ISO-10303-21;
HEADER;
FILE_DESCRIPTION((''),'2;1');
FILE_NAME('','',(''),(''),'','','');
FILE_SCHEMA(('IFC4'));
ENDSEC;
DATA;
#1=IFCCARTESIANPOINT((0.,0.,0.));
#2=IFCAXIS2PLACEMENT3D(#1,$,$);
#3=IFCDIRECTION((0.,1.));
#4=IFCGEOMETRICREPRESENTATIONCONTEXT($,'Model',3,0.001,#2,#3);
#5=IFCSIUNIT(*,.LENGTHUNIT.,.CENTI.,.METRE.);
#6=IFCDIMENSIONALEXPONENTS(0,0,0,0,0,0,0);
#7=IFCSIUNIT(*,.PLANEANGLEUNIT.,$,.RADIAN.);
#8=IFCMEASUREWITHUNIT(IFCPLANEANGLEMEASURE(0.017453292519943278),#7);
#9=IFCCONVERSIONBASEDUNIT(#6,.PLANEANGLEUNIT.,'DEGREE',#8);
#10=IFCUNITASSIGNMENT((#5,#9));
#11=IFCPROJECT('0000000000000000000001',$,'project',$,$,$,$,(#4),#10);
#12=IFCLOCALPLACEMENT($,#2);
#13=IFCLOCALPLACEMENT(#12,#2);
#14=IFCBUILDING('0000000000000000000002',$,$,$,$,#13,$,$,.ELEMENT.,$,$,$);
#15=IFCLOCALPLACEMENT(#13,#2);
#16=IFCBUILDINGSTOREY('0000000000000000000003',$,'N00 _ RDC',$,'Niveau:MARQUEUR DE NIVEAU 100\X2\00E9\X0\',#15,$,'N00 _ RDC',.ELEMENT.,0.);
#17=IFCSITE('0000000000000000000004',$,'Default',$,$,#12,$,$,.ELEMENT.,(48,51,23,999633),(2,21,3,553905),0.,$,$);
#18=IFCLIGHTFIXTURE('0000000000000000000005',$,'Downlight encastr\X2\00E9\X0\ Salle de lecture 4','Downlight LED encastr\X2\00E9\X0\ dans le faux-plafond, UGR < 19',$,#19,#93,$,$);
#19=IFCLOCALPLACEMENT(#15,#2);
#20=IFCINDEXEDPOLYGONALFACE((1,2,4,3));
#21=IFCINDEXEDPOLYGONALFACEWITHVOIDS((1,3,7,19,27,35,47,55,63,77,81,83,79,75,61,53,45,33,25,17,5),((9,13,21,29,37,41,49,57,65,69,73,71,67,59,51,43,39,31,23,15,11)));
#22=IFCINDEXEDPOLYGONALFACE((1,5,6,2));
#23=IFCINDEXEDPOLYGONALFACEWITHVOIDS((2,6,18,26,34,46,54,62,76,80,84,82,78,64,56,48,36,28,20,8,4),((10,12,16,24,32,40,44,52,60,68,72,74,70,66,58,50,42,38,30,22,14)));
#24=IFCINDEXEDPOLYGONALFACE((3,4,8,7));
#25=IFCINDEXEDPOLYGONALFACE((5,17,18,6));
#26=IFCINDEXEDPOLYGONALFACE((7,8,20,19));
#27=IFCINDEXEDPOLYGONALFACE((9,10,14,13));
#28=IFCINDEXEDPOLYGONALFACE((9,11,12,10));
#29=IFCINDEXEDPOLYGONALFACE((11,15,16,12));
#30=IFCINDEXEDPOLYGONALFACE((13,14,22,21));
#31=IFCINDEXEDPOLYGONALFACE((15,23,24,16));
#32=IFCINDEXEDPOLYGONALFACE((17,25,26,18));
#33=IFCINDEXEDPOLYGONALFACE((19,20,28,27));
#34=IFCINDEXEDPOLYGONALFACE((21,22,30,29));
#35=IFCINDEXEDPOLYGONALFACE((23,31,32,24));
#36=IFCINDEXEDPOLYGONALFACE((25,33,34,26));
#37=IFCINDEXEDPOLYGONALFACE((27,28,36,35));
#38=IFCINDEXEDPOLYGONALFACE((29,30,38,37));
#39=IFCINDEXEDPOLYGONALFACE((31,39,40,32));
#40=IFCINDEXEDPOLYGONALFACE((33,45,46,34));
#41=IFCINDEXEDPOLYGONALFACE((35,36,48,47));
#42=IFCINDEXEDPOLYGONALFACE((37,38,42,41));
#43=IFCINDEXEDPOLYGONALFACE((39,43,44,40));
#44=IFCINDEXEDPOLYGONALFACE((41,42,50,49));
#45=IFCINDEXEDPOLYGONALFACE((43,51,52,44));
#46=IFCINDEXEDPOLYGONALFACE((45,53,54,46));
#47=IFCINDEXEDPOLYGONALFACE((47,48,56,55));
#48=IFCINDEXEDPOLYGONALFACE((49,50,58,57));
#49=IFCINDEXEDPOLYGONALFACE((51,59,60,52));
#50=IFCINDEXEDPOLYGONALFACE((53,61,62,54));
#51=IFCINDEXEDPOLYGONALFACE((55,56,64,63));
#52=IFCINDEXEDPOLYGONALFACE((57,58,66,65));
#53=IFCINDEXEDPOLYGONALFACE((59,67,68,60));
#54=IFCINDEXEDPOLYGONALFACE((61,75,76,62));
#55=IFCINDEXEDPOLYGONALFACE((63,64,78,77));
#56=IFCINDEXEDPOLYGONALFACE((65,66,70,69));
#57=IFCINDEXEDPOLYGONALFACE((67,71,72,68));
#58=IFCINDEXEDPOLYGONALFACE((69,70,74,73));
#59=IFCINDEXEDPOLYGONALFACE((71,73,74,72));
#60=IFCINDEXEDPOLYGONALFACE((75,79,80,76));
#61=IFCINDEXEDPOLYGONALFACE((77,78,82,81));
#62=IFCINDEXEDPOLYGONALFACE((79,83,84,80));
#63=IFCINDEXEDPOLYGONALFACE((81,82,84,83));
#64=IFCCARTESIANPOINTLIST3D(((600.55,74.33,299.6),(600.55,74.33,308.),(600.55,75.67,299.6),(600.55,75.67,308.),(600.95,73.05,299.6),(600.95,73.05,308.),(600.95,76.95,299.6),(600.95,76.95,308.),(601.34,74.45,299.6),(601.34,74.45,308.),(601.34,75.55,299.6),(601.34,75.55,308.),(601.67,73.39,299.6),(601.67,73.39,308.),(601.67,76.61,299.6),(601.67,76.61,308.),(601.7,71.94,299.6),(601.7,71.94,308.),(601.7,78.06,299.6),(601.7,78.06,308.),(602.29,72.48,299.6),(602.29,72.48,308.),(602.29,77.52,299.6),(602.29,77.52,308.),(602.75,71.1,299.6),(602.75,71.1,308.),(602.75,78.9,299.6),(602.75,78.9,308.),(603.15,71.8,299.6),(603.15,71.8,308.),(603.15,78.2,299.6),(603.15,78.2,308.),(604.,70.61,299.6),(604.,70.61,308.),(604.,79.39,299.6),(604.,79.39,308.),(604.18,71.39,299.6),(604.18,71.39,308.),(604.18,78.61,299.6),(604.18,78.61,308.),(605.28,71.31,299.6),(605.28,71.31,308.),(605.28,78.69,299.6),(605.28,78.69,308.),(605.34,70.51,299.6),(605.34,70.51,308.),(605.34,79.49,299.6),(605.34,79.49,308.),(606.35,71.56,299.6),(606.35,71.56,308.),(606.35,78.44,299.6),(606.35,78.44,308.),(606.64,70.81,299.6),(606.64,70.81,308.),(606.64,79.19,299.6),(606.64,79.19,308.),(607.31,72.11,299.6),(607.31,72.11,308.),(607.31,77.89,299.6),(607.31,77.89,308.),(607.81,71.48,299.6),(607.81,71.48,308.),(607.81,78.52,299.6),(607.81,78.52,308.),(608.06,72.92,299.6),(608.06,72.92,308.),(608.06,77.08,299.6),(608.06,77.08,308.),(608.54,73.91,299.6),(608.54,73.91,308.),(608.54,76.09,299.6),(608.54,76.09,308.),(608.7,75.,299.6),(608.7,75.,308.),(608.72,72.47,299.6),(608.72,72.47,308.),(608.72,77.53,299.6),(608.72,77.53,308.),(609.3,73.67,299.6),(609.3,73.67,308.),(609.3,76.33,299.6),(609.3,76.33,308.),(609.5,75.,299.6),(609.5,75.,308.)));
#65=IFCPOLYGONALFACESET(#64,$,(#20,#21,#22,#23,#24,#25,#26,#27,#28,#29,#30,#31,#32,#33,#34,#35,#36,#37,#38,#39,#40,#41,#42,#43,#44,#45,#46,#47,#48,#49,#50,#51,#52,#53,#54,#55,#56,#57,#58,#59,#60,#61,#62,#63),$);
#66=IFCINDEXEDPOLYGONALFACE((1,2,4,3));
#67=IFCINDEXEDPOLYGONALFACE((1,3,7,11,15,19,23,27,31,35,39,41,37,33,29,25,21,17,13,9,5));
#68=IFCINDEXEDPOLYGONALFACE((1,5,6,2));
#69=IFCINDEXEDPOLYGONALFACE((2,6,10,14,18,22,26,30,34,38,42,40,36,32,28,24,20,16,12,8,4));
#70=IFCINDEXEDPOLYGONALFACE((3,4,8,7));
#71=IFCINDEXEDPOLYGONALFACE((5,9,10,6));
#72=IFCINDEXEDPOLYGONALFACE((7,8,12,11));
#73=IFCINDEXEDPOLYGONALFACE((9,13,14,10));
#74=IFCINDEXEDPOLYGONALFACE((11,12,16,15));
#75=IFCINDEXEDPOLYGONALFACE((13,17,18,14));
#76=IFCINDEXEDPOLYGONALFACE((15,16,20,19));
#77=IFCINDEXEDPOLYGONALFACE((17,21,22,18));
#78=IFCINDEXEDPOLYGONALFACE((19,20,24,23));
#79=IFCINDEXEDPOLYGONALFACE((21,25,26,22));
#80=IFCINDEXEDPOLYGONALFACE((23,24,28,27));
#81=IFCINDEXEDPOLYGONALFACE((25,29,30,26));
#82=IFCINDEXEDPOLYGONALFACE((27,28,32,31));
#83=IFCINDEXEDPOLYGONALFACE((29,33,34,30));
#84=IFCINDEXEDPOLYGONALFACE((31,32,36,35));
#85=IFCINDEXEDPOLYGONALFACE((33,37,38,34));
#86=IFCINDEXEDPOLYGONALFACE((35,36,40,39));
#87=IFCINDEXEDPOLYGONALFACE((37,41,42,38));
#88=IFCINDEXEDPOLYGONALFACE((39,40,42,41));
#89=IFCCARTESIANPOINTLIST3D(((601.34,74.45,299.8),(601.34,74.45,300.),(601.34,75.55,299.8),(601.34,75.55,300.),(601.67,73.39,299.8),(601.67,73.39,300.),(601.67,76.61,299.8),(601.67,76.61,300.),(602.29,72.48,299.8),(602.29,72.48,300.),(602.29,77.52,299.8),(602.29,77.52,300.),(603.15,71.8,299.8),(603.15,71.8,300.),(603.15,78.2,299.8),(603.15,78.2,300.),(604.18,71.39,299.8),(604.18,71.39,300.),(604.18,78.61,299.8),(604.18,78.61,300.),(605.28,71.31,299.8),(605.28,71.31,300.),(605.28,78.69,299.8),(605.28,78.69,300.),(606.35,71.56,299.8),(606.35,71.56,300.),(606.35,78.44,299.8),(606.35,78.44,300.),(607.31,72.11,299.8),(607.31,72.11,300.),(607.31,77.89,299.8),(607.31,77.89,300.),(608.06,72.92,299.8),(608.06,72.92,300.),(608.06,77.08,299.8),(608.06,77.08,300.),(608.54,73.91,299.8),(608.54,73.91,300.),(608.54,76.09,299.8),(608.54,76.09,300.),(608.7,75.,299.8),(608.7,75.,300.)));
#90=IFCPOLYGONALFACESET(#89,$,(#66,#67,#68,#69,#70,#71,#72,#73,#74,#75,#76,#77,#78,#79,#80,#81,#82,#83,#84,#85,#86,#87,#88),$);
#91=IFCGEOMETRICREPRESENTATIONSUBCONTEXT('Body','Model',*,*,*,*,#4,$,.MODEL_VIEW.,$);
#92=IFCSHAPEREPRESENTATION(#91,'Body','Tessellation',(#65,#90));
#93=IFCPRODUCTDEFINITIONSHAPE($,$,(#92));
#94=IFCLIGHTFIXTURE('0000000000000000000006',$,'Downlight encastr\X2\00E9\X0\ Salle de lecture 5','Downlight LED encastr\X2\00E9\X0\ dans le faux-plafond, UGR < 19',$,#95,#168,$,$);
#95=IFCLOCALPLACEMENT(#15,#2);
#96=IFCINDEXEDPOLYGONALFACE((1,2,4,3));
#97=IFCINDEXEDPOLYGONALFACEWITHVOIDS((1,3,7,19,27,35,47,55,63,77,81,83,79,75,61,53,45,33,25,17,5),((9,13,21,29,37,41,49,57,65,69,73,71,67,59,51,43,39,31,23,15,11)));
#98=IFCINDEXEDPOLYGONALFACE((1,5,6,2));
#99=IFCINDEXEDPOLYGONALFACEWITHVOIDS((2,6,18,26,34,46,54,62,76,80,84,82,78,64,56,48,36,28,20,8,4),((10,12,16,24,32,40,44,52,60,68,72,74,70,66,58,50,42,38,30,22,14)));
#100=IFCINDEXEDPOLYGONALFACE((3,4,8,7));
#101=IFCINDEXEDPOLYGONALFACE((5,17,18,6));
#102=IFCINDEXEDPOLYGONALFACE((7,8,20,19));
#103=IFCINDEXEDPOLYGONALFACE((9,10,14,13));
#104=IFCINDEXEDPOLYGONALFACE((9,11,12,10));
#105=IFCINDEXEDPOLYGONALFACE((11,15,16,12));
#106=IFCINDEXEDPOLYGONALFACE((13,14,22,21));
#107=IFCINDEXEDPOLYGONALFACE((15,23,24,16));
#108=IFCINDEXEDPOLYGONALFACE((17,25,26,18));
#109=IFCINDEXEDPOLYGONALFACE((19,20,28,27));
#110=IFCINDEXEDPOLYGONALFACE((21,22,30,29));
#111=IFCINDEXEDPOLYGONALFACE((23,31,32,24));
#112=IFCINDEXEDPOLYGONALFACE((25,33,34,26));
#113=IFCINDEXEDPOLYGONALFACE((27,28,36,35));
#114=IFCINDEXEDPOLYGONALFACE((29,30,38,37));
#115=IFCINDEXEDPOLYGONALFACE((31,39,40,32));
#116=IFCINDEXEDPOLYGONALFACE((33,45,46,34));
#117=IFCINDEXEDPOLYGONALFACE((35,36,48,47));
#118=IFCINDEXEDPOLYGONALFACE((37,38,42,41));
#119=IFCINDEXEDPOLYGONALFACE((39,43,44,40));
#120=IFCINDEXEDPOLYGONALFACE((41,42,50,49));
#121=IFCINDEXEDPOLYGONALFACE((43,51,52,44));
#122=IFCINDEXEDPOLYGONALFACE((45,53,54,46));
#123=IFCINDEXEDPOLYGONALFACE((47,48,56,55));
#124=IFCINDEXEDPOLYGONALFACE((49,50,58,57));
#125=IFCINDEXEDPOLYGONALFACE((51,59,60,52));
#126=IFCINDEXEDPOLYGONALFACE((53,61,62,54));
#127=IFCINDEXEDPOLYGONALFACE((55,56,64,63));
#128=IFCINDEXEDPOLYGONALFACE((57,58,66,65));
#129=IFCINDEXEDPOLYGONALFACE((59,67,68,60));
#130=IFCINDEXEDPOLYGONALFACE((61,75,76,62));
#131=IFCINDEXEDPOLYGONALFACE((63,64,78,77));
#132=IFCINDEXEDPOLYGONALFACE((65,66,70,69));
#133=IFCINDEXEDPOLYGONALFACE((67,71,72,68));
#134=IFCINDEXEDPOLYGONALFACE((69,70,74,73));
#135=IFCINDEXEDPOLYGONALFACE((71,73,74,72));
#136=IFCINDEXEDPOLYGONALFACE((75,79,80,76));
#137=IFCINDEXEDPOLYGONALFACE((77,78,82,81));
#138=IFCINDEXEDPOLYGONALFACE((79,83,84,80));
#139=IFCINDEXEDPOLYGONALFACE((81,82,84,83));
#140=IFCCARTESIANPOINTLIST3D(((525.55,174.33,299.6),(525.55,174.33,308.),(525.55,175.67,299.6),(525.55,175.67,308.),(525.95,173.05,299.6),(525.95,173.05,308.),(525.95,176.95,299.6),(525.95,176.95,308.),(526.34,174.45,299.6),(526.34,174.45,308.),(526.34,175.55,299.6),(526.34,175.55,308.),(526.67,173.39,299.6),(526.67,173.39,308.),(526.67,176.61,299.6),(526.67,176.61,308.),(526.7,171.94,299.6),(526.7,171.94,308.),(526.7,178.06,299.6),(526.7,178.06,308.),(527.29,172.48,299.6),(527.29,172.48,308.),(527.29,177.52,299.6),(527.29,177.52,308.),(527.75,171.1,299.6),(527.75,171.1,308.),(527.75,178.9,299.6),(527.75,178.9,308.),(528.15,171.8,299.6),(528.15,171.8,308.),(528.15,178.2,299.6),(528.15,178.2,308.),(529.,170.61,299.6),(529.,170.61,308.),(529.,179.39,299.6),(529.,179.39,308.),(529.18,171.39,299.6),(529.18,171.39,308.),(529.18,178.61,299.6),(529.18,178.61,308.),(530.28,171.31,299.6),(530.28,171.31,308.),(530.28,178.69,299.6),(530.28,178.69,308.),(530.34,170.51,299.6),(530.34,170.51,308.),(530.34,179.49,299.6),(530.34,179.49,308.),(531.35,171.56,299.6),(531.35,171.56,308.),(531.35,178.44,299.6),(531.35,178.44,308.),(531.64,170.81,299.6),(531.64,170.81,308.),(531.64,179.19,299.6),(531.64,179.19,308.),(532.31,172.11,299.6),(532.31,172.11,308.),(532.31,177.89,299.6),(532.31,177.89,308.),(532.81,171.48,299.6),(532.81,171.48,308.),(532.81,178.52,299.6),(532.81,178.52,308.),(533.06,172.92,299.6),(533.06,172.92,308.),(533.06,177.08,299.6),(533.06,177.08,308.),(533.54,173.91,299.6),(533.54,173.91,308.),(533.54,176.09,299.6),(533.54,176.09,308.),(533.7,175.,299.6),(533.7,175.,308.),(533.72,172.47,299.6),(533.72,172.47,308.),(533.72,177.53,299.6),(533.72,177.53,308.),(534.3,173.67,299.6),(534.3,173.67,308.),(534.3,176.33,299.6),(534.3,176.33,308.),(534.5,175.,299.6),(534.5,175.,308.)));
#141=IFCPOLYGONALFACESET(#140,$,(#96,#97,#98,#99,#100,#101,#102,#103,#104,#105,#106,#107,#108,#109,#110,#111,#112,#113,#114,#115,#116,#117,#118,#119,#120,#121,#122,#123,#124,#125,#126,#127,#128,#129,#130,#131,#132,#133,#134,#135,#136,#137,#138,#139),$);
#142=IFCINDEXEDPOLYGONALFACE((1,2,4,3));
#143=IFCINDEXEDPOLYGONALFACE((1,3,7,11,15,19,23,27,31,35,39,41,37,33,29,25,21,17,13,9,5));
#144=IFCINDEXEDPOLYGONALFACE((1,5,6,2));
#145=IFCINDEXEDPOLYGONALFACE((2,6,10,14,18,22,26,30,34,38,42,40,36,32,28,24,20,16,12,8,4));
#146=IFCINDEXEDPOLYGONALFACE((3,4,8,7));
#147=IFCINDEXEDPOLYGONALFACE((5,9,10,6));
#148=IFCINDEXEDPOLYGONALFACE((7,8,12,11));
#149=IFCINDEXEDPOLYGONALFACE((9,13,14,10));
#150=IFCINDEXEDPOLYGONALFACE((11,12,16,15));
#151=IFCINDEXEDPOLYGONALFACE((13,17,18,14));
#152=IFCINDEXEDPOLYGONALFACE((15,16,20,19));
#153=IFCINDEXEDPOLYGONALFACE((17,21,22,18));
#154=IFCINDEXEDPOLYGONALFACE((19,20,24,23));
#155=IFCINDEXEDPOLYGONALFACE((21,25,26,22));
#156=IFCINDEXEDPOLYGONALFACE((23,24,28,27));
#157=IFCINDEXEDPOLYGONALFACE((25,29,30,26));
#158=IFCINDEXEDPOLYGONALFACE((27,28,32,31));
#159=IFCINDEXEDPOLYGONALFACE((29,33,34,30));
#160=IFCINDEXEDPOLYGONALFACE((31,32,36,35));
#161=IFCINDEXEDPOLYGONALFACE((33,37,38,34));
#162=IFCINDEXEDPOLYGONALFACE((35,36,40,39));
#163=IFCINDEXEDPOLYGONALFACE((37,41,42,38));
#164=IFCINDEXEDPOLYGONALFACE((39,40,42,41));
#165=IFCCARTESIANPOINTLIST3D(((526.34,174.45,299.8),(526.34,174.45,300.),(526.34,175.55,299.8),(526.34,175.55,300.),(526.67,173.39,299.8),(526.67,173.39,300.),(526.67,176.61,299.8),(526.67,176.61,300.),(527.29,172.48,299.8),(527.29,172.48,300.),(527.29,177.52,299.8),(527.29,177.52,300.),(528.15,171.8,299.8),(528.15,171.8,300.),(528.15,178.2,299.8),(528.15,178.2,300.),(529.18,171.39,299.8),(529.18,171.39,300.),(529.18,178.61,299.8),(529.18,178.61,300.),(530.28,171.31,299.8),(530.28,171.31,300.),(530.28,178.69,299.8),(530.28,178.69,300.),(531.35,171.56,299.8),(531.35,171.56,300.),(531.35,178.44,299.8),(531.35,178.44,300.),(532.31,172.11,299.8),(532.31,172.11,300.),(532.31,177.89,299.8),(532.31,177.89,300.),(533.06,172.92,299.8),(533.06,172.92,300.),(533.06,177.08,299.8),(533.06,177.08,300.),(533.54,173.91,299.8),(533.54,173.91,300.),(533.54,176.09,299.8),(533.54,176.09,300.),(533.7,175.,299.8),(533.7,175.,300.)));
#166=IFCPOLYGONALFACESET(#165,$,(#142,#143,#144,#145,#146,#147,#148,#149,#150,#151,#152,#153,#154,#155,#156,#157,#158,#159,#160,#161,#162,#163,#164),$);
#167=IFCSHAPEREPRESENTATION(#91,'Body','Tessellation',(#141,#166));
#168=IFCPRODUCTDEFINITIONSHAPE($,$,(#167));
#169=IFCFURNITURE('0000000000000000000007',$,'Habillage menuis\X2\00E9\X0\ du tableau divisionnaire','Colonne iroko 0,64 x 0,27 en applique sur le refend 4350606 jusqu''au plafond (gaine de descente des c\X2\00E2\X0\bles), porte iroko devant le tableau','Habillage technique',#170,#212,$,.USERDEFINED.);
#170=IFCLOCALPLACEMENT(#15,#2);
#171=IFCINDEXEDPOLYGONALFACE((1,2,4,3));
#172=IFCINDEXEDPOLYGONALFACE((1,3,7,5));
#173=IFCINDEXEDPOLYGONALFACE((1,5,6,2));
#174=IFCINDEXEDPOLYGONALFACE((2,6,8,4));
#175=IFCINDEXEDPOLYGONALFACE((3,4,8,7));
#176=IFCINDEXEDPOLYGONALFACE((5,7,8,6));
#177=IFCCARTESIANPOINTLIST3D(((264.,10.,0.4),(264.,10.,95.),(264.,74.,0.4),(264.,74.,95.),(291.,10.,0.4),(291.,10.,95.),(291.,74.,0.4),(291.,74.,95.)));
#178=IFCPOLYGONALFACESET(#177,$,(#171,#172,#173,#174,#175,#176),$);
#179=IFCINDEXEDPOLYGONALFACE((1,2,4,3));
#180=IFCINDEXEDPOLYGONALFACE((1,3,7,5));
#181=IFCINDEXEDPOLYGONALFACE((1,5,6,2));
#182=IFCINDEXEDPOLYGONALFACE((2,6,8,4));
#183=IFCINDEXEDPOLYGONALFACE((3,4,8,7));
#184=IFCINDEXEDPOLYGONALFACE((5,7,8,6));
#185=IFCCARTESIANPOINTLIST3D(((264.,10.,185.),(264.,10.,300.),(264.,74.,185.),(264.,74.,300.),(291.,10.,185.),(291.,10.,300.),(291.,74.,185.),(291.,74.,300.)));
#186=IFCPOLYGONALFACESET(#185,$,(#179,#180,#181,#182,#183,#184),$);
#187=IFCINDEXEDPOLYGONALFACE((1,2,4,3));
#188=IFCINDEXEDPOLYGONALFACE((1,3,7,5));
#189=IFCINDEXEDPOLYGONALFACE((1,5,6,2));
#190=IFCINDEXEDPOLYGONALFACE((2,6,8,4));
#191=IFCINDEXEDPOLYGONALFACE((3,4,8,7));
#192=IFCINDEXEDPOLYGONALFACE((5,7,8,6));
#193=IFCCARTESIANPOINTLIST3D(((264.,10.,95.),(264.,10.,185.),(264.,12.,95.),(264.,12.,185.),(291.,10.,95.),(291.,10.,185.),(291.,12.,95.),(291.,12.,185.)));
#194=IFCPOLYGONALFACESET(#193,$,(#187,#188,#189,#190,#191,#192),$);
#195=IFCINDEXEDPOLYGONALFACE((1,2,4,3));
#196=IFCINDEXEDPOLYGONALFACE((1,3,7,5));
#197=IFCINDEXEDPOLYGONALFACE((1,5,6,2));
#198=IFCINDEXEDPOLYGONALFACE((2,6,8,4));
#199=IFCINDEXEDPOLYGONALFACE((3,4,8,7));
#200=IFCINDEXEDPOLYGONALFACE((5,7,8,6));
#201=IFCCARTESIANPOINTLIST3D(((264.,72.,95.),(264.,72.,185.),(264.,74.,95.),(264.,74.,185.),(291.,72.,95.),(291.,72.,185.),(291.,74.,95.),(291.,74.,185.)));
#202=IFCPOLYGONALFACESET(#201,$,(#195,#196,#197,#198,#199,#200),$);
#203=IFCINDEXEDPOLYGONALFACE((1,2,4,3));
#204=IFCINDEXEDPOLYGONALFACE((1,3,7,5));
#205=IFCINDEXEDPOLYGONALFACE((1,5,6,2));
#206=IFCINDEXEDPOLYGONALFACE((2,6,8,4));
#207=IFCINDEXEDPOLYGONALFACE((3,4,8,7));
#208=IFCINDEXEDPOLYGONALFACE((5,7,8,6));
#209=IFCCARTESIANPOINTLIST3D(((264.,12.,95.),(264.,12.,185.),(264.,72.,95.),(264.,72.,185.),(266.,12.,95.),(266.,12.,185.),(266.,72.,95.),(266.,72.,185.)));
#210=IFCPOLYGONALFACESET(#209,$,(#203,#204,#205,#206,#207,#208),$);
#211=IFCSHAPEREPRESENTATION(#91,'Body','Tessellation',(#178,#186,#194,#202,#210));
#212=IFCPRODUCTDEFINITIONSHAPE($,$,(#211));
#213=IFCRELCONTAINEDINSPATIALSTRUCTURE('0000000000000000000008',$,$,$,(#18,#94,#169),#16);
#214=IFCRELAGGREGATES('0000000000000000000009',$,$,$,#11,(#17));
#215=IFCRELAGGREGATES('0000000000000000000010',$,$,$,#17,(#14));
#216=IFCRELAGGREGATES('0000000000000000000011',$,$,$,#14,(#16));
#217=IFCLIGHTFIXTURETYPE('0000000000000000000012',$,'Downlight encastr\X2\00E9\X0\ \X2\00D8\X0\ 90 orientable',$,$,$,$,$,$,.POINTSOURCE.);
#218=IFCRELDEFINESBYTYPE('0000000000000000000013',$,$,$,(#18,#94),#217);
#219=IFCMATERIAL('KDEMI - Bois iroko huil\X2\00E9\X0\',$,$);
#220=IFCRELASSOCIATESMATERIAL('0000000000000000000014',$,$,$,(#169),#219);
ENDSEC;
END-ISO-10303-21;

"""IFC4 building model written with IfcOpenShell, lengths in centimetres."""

from ifc_helpers import new_model, entity, si_unit, converted_unit, direction, frame, frame_2d, origin, origin_with_axes, place, context, subcontext, project, spatial, rectangle, circle, hollow_circle, extrude, material, type_object, element, save


model = new_model("IFC4")

# Units and contexts
model_context = context("Model", 3, precision=0.001, world=origin(), true_north=direction((0.0, 1.0)))
body_context = subcontext(model_context, "Body", "Model", "MODEL_VIEW")
ifc_project = project(units=[si_unit("LENGTHUNIT", "METRE", prefix="CENTI"), converted_unit("PLANEANGLEUNIT", "DEGREE", entity("IfcPlaneAngleMeasure", 0.017453292519943278), si_unit("PLANEANGLEUNIT", "RADIAN"), dimensions=[0, 0, 0, 0, 0, 0, 0])], contexts=[model_context])

# Site, building, storey
site_placement = place(None, origin())
site = spatial("IfcSite", under=ifc_project, at=site_placement, Name="Default", CompositionType="ELEMENT", RefLatitude=(48, 51, 23, 999633), RefLongitude=(2, 21, 3, 553905), RefElevation=0.0)
building_placement = place(site_placement, origin())
building = spatial("IfcBuilding", under=site, at=building_placement, CompositionType="ELEMENT")
storey_placement = place(building_placement, origin())
storey = spatial("IfcBuildingStorey", under=building, at=storey_placement, Name="N00 _ RDC", ObjectType="Niveau:MARQUEUR DE NIVEAU 100é", LongName="N00 _ RDC", CompositionType="ELEMENT", Elevation=0.0)

# Shared definitions
ifc_material_1 = material(Name="KDEMI - Bois iroko huilé")

# Light fixtures
light_fixture_type_1 = type_object("IfcLightFixtureType", Name="Downlight encastré Ø 90 orientable", PredefinedType="POINTSOURCE")
light_fixture_1_placement = place(storey_placement, origin_with_axes())
element("IfcLightFixture", 1, at=light_fixture_1_placement, inside=storey, type_object=light_fixture_type_1, Name="Downlight encastré Salle de lecture 4", Description="Downlight LED encastré dans le faux-plafond, UGR < 19", context=body_context, shape_type="SweptSolid", body=[
    extrude(hollow_circle(Radius=4.5, WallThickness=0.8, at=frame_2d((605.0, 75.0))), frame((0.0, 0.0, 299.6)), (0.0, 0.0, 1.0), 8.4),
    extrude(circle(Radius=3.7, at=frame_2d((605.0, 75.0))), frame((0.0, 0.0, 299.8)), (0.0, 0.0, 1.0), 0.2),
])
light_fixture_2_placement = place(storey_placement, origin_with_axes())
element("IfcLightFixture", 2, at=light_fixture_2_placement, inside=storey, type_object=light_fixture_type_1, Name="Downlight encastré Salle de lecture 5", Description="Downlight LED encastré dans le faux-plafond, UGR < 19", context=body_context, shape_type="SweptSolid", body=[
    extrude(hollow_circle(Radius=4.5, WallThickness=0.8, at=frame_2d((530.0, 175.0))), frame((0.0, 0.0, 299.6)), (0.0, 0.0, 1.0), 8.4),
    extrude(circle(Radius=3.7, at=frame_2d((530.0, 175.0))), frame((0.0, 0.0, 299.8)), (0.0, 0.0, 1.0), 0.2),
])

# Furniture
furniture_placement = place(storey_placement, origin_with_axes())
element("IfcFurniture", 3, at=furniture_placement, inside=storey, material=ifc_material_1, Name="Habillage menuisé du tableau divisionnaire", Description="Colonne iroko 0,64 x 0,27 en applique sur le refend 4350606 jusqu'au plafond (gaine de descente des câbles), porte iroko devant le tableau", ObjectType="Habillage technique", PredefinedType="USERDEFINED", context=body_context, shape_type="SweptSolid", body=[
    extrude(rectangle(XDim=27.0, YDim=64.0, at=frame_2d((277.5, 42.0))), frame((0.0, 0.0, 0.4)), (0.0, 0.0, 1.0), 94.6),
    extrude(rectangle(XDim=27.0, YDim=64.0, at=frame_2d((277.5, 42.0))), frame((0.0, 0.0, 185.0)), (0.0, 0.0, 1.0), 115.0),
    extrude(rectangle(XDim=27.0, YDim=2.0, at=frame_2d((277.5, 11.0))), frame((0.0, 0.0, 95.0)), (0.0, 0.0, 1.0), 90.0),
    extrude(rectangle(XDim=27.0, YDim=2.0, at=frame_2d((277.5, 73.0))), frame((0.0, 0.0, 95.0)), (0.0, 0.0, 1.0), 90.0),
    extrude(rectangle(XDim=2.0, YDim=60.0, at=frame_2d((265.0, 42.0))), frame((0.0, 0.0, 95.0)), (0.0, 0.0, 1.0), 90.0),
])

save(model, "model.ifc")
